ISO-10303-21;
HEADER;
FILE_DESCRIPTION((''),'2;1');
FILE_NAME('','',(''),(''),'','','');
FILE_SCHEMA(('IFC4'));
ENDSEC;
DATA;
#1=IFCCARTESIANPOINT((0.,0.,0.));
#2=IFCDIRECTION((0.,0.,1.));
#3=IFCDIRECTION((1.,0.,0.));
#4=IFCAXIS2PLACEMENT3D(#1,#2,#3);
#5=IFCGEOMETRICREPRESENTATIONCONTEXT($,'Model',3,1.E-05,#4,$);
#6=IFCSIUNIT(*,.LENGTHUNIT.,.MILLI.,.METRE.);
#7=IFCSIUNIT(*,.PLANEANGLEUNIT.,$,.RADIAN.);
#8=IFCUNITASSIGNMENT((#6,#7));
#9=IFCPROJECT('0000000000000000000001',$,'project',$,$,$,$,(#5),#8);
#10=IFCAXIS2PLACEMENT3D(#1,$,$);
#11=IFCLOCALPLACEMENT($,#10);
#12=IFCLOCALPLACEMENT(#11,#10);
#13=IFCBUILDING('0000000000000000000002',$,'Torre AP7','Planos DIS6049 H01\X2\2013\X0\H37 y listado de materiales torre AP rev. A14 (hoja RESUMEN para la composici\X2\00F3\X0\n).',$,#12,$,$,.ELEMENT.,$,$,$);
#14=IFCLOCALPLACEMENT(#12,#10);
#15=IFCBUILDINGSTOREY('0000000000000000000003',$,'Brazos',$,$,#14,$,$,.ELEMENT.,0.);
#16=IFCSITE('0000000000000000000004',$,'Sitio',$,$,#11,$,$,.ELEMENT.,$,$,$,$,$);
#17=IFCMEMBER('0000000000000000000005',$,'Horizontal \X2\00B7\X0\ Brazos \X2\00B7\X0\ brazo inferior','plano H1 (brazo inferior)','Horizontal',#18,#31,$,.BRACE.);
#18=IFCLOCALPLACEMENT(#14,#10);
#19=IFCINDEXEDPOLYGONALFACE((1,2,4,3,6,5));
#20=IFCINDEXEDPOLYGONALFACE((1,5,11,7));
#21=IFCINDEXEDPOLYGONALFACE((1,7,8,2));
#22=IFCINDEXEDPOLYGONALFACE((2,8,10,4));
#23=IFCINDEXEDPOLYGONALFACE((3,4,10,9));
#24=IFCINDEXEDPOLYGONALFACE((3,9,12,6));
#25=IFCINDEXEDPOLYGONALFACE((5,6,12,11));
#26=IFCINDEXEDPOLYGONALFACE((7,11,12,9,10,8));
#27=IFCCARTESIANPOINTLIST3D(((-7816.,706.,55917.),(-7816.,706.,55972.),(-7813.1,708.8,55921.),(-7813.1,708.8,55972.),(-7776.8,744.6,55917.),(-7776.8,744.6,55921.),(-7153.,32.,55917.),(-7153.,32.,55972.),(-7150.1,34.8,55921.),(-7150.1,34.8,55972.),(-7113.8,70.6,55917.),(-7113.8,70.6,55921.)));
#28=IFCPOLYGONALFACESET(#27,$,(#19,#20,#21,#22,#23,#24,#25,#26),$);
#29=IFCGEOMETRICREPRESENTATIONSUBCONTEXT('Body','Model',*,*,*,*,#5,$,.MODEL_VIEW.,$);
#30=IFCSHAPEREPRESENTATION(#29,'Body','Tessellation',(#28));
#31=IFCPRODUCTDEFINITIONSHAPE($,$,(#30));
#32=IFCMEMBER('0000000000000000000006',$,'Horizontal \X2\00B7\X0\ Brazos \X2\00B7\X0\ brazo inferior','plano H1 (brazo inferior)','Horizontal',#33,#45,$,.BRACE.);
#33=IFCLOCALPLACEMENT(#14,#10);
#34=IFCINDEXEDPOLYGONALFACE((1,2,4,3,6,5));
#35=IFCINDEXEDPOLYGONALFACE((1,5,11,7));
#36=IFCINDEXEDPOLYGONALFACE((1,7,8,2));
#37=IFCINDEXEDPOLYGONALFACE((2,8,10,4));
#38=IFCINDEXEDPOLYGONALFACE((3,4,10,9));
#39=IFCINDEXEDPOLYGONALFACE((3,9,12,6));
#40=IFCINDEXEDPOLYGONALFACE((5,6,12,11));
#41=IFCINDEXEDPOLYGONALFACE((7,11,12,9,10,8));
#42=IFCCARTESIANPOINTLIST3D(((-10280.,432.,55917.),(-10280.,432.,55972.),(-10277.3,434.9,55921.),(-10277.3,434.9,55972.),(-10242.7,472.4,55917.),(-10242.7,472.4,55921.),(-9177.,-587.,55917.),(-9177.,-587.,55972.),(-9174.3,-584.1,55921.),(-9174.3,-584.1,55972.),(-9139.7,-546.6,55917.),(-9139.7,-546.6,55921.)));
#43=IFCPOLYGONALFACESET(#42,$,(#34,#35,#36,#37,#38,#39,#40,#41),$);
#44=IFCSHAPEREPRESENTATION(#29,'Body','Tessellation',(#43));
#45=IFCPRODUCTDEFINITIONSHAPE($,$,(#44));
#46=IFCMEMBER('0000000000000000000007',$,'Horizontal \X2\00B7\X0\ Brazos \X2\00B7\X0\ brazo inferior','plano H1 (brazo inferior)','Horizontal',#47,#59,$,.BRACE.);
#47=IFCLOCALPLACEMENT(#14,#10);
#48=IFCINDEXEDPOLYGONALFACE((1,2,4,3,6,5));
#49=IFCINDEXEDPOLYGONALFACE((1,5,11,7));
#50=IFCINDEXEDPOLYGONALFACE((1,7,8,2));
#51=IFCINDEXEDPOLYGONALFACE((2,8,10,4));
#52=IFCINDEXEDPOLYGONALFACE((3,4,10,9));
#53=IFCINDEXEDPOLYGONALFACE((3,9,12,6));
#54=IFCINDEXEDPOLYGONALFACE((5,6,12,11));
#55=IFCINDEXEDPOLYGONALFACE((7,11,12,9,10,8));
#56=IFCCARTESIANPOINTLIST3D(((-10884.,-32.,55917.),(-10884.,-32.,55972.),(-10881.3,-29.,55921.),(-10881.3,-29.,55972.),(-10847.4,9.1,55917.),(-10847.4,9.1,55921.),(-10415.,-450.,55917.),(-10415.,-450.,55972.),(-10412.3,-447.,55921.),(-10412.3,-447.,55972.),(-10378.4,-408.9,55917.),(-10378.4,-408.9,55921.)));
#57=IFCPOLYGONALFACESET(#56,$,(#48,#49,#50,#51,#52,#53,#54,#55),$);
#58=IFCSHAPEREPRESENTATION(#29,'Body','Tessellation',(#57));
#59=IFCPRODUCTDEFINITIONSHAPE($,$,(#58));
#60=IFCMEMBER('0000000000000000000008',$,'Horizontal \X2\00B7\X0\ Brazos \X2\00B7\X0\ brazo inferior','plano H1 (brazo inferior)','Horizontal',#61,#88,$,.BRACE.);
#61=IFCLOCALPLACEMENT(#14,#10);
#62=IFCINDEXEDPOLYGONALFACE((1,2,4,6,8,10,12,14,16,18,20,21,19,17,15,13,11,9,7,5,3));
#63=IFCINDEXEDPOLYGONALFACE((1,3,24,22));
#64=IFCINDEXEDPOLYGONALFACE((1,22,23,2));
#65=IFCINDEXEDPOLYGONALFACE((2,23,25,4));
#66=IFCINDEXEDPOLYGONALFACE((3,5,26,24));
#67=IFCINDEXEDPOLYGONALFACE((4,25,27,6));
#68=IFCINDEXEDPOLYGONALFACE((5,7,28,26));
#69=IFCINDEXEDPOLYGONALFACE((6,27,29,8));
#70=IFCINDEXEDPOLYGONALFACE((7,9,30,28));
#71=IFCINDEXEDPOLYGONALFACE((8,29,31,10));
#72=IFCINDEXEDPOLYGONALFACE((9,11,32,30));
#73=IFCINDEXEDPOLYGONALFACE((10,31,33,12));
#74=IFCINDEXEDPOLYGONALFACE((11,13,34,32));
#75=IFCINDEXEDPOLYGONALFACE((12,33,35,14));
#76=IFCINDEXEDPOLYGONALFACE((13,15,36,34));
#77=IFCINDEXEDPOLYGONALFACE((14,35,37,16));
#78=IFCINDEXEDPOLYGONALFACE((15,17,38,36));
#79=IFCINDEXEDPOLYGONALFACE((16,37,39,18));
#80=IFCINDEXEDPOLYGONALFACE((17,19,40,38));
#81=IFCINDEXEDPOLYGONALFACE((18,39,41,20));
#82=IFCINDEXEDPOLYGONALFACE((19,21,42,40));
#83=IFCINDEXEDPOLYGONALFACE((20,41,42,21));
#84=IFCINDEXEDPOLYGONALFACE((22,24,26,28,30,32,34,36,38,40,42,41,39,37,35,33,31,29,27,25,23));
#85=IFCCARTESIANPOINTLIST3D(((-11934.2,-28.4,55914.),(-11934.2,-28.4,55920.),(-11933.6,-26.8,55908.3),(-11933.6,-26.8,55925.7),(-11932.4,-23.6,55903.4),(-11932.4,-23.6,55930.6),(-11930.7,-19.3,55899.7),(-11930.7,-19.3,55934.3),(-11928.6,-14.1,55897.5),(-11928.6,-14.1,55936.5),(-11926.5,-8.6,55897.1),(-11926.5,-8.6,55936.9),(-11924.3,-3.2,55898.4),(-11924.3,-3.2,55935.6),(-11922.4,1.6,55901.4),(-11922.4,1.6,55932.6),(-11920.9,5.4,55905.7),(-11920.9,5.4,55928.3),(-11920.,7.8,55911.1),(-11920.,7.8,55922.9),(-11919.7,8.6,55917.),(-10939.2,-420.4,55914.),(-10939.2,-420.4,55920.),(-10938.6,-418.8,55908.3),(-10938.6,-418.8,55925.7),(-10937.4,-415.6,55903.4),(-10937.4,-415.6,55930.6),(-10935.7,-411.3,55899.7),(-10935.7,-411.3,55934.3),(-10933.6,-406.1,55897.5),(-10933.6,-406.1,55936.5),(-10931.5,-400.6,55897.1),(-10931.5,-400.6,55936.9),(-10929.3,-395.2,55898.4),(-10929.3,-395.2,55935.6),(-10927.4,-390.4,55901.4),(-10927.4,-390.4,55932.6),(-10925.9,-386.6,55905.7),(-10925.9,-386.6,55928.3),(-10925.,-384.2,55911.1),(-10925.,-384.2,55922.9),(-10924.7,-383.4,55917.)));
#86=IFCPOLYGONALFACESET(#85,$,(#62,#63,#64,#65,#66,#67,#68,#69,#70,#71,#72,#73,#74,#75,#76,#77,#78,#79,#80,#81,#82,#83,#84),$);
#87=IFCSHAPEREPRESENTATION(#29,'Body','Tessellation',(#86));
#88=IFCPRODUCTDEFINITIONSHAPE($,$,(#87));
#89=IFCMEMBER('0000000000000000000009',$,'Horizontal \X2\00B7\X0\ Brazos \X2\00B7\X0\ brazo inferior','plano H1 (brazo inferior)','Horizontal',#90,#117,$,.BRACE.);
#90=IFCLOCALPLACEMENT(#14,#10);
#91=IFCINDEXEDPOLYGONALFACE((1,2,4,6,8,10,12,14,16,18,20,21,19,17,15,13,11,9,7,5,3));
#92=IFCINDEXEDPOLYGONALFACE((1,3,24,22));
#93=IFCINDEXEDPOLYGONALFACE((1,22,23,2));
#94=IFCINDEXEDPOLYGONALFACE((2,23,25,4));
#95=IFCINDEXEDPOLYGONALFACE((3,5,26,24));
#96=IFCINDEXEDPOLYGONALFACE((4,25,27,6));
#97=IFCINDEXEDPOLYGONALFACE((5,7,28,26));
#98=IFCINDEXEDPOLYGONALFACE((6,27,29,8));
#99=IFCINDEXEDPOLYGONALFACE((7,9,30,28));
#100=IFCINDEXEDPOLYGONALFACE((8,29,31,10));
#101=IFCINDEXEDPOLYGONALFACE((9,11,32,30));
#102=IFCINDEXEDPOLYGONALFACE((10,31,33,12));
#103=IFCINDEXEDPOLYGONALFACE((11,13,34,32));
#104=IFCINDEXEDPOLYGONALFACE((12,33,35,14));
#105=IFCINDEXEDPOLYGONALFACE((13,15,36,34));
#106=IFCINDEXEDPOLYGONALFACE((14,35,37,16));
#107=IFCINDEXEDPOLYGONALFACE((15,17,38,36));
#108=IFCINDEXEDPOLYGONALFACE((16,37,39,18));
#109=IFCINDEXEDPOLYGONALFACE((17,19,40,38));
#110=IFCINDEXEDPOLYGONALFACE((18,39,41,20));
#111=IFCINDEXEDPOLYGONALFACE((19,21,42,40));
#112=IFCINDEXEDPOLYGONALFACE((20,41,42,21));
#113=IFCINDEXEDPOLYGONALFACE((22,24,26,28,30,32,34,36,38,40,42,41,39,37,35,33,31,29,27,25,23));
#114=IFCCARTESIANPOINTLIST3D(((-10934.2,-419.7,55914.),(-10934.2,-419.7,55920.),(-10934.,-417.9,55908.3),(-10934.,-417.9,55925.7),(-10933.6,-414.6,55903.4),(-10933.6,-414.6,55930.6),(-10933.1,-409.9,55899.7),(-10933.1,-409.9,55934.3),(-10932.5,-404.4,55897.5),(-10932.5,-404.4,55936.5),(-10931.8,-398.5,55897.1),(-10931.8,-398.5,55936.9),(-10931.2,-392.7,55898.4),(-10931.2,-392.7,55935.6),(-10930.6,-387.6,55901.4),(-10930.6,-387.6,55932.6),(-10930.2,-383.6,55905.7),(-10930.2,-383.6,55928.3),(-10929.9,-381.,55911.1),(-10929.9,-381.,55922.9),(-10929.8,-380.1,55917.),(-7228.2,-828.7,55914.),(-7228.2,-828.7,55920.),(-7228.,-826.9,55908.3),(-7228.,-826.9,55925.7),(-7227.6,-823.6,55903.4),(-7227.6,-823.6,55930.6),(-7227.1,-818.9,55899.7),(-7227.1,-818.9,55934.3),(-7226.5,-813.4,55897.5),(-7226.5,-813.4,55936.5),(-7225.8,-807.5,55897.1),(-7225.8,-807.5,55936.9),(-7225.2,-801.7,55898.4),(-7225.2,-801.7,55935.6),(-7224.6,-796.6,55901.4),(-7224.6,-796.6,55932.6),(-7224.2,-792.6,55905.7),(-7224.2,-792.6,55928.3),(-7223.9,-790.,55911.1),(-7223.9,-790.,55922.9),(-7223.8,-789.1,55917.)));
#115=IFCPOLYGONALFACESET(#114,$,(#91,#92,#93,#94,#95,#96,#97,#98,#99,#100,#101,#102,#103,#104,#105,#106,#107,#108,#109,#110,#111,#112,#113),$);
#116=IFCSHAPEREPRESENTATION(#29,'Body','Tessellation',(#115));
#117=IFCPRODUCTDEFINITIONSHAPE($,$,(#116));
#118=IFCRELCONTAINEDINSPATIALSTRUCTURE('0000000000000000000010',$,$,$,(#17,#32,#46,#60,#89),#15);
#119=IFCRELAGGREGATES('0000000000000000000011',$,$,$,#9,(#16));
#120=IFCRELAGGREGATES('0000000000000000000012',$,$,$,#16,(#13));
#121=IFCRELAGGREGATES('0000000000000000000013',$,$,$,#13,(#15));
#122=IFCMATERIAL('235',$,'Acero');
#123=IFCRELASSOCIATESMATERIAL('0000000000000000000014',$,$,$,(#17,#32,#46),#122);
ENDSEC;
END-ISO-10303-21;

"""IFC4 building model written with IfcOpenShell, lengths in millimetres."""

from ifc_helpers import new_model, si_unit, frame, frame_2d, origin, origin_with_axes, place, context, subcontext, project, spatial, circle, l_section, extrude, material, element, save


model = new_model("IFC4")

# Units and contexts
model_context = context("Model", 3, precision=1e-05, world=origin_with_axes())
body_context = subcontext(model_context, "Body", "Model", "MODEL_VIEW")
ifc_project = project(units=[si_unit("LENGTHUNIT", "METRE", prefix="MILLI"), si_unit("PLANEANGLEUNIT", "RADIAN")], contexts=[model_context])

# Site, building, storey
site_placement = place(None, origin())
site = spatial("IfcSite", under=ifc_project, at=site_placement, Name="Sitio", CompositionType="ELEMENT")
building_placement = place(site_placement, origin())
building = spatial("IfcBuilding", under=site, at=building_placement, Name="Torre AP7", Description="Planos DIS6049 H01–H37 y listado de materiales torre AP rev. A14 (hoja RESUMEN para la composición).", CompositionType="ELEMENT")
storey_placement = place(building_placement, origin())
storey = spatial("IfcBuildingStorey", under=building, at=storey_placement, Name="Brazos", CompositionType="ELEMENT", Elevation=0.0)

# Members
ifc_material_1 = material(Name="235", Category="Acero")
member_1_placement = place(storey_placement, frame((-7816.0, 706.0, 55917.0), z_axis=(0.701265, -0.7129, 0.0), x_axis=(0.7129, 0.701265, 0.0)))
element("IfcMember", 1, at=member_1_placement, inside=storey, material=ifc_material_1, Name="Horizontal · Brazos · brazo inferior", Description="plano H1 (brazo inferior)", ObjectType="Horizontal", PredefinedType="BRACE", context=body_context, shape_type="SweptSolid", body=[
    extrude(l_section(Depth=55.0, Width=55.0, Thickness=4.0, at=frame_2d((27.5, 27.5))), None, (0.0, 0.0, 1.0), 945.4),
])
member_2_placement = place(storey_placement, frame((-10280.0, 432.0, 55917.0), z_axis=(0.734523, -0.678584, 0.0), x_axis=(0.678584, 0.734523, 0.0)))
element("IfcMember", 2, at=member_2_placement, inside=storey, material=ifc_material_1, Name="Horizontal · Brazos · brazo inferior", Description="plano H1 (brazo inferior)", ObjectType="Horizontal", PredefinedType="BRACE", context=body_context, shape_type="SweptSolid", body=[
    extrude(l_section(Depth=55.0, Width=55.0, Thickness=4.0, at=frame_2d((27.5, 27.5))), None, (0.0, 0.0, 1.0), 1501.7),
])
member_3_placement = place(storey_placement, frame((-10884.0, -32.0, 55917.0), z_axis=(0.74653, -0.665351, 0.0), x_axis=(0.665351, 0.74653, 0.0)))
element("IfcMember", 3, at=member_3_placement, inside=storey, material=ifc_material_1, Name="Horizontal · Brazos · brazo inferior", Description="plano H1 (brazo inferior)", ObjectType="Horizontal", PredefinedType="BRACE", context=body_context, shape_type="SweptSolid", body=[
    extrude(l_section(Depth=55.0, Width=55.0, Thickness=4.0, at=frame_2d((27.5, 27.5))), None, (0.0, 0.0, 1.0), 628.2),
])
member_4_placement = place(storey_placement, frame((-11927.0, -10.0, 55917.0), z_axis=(0.930399, -0.366549, 0.0), x_axis=(0.366549, 0.930399, 0.0)))
element("IfcMember", 4, at=member_4_placement, inside=storey, Name="Horizontal · Brazos · brazo inferior", Description="plano H1 (brazo inferior)", ObjectType="Horizontal", PredefinedType="BRACE", context=body_context, shape_type="SweptSolid", body=[
    extrude(circle(Radius=20.0), None, (0.0, 0.0, 1.0), 1069.4),
])
member_5_placement = place(storey_placement, frame((-10932.0, -400.0, 55917.0), z_axis=(0.993965, -0.109696, 0.0), x_axis=(0.109696, 0.993965, 0.0)))
element("IfcMember", 5, at=member_5_placement, inside=storey, Name="Horizontal · Brazos · brazo inferior", Description="plano H1 (brazo inferior)", ObjectType="Horizontal", PredefinedType="BRACE", context=body_context, shape_type="SweptSolid", body=[
    extrude(circle(Radius=20.0), None, (0.0, 0.0, 1.0), 3728.5),
])

save(model, "model.ifc")
